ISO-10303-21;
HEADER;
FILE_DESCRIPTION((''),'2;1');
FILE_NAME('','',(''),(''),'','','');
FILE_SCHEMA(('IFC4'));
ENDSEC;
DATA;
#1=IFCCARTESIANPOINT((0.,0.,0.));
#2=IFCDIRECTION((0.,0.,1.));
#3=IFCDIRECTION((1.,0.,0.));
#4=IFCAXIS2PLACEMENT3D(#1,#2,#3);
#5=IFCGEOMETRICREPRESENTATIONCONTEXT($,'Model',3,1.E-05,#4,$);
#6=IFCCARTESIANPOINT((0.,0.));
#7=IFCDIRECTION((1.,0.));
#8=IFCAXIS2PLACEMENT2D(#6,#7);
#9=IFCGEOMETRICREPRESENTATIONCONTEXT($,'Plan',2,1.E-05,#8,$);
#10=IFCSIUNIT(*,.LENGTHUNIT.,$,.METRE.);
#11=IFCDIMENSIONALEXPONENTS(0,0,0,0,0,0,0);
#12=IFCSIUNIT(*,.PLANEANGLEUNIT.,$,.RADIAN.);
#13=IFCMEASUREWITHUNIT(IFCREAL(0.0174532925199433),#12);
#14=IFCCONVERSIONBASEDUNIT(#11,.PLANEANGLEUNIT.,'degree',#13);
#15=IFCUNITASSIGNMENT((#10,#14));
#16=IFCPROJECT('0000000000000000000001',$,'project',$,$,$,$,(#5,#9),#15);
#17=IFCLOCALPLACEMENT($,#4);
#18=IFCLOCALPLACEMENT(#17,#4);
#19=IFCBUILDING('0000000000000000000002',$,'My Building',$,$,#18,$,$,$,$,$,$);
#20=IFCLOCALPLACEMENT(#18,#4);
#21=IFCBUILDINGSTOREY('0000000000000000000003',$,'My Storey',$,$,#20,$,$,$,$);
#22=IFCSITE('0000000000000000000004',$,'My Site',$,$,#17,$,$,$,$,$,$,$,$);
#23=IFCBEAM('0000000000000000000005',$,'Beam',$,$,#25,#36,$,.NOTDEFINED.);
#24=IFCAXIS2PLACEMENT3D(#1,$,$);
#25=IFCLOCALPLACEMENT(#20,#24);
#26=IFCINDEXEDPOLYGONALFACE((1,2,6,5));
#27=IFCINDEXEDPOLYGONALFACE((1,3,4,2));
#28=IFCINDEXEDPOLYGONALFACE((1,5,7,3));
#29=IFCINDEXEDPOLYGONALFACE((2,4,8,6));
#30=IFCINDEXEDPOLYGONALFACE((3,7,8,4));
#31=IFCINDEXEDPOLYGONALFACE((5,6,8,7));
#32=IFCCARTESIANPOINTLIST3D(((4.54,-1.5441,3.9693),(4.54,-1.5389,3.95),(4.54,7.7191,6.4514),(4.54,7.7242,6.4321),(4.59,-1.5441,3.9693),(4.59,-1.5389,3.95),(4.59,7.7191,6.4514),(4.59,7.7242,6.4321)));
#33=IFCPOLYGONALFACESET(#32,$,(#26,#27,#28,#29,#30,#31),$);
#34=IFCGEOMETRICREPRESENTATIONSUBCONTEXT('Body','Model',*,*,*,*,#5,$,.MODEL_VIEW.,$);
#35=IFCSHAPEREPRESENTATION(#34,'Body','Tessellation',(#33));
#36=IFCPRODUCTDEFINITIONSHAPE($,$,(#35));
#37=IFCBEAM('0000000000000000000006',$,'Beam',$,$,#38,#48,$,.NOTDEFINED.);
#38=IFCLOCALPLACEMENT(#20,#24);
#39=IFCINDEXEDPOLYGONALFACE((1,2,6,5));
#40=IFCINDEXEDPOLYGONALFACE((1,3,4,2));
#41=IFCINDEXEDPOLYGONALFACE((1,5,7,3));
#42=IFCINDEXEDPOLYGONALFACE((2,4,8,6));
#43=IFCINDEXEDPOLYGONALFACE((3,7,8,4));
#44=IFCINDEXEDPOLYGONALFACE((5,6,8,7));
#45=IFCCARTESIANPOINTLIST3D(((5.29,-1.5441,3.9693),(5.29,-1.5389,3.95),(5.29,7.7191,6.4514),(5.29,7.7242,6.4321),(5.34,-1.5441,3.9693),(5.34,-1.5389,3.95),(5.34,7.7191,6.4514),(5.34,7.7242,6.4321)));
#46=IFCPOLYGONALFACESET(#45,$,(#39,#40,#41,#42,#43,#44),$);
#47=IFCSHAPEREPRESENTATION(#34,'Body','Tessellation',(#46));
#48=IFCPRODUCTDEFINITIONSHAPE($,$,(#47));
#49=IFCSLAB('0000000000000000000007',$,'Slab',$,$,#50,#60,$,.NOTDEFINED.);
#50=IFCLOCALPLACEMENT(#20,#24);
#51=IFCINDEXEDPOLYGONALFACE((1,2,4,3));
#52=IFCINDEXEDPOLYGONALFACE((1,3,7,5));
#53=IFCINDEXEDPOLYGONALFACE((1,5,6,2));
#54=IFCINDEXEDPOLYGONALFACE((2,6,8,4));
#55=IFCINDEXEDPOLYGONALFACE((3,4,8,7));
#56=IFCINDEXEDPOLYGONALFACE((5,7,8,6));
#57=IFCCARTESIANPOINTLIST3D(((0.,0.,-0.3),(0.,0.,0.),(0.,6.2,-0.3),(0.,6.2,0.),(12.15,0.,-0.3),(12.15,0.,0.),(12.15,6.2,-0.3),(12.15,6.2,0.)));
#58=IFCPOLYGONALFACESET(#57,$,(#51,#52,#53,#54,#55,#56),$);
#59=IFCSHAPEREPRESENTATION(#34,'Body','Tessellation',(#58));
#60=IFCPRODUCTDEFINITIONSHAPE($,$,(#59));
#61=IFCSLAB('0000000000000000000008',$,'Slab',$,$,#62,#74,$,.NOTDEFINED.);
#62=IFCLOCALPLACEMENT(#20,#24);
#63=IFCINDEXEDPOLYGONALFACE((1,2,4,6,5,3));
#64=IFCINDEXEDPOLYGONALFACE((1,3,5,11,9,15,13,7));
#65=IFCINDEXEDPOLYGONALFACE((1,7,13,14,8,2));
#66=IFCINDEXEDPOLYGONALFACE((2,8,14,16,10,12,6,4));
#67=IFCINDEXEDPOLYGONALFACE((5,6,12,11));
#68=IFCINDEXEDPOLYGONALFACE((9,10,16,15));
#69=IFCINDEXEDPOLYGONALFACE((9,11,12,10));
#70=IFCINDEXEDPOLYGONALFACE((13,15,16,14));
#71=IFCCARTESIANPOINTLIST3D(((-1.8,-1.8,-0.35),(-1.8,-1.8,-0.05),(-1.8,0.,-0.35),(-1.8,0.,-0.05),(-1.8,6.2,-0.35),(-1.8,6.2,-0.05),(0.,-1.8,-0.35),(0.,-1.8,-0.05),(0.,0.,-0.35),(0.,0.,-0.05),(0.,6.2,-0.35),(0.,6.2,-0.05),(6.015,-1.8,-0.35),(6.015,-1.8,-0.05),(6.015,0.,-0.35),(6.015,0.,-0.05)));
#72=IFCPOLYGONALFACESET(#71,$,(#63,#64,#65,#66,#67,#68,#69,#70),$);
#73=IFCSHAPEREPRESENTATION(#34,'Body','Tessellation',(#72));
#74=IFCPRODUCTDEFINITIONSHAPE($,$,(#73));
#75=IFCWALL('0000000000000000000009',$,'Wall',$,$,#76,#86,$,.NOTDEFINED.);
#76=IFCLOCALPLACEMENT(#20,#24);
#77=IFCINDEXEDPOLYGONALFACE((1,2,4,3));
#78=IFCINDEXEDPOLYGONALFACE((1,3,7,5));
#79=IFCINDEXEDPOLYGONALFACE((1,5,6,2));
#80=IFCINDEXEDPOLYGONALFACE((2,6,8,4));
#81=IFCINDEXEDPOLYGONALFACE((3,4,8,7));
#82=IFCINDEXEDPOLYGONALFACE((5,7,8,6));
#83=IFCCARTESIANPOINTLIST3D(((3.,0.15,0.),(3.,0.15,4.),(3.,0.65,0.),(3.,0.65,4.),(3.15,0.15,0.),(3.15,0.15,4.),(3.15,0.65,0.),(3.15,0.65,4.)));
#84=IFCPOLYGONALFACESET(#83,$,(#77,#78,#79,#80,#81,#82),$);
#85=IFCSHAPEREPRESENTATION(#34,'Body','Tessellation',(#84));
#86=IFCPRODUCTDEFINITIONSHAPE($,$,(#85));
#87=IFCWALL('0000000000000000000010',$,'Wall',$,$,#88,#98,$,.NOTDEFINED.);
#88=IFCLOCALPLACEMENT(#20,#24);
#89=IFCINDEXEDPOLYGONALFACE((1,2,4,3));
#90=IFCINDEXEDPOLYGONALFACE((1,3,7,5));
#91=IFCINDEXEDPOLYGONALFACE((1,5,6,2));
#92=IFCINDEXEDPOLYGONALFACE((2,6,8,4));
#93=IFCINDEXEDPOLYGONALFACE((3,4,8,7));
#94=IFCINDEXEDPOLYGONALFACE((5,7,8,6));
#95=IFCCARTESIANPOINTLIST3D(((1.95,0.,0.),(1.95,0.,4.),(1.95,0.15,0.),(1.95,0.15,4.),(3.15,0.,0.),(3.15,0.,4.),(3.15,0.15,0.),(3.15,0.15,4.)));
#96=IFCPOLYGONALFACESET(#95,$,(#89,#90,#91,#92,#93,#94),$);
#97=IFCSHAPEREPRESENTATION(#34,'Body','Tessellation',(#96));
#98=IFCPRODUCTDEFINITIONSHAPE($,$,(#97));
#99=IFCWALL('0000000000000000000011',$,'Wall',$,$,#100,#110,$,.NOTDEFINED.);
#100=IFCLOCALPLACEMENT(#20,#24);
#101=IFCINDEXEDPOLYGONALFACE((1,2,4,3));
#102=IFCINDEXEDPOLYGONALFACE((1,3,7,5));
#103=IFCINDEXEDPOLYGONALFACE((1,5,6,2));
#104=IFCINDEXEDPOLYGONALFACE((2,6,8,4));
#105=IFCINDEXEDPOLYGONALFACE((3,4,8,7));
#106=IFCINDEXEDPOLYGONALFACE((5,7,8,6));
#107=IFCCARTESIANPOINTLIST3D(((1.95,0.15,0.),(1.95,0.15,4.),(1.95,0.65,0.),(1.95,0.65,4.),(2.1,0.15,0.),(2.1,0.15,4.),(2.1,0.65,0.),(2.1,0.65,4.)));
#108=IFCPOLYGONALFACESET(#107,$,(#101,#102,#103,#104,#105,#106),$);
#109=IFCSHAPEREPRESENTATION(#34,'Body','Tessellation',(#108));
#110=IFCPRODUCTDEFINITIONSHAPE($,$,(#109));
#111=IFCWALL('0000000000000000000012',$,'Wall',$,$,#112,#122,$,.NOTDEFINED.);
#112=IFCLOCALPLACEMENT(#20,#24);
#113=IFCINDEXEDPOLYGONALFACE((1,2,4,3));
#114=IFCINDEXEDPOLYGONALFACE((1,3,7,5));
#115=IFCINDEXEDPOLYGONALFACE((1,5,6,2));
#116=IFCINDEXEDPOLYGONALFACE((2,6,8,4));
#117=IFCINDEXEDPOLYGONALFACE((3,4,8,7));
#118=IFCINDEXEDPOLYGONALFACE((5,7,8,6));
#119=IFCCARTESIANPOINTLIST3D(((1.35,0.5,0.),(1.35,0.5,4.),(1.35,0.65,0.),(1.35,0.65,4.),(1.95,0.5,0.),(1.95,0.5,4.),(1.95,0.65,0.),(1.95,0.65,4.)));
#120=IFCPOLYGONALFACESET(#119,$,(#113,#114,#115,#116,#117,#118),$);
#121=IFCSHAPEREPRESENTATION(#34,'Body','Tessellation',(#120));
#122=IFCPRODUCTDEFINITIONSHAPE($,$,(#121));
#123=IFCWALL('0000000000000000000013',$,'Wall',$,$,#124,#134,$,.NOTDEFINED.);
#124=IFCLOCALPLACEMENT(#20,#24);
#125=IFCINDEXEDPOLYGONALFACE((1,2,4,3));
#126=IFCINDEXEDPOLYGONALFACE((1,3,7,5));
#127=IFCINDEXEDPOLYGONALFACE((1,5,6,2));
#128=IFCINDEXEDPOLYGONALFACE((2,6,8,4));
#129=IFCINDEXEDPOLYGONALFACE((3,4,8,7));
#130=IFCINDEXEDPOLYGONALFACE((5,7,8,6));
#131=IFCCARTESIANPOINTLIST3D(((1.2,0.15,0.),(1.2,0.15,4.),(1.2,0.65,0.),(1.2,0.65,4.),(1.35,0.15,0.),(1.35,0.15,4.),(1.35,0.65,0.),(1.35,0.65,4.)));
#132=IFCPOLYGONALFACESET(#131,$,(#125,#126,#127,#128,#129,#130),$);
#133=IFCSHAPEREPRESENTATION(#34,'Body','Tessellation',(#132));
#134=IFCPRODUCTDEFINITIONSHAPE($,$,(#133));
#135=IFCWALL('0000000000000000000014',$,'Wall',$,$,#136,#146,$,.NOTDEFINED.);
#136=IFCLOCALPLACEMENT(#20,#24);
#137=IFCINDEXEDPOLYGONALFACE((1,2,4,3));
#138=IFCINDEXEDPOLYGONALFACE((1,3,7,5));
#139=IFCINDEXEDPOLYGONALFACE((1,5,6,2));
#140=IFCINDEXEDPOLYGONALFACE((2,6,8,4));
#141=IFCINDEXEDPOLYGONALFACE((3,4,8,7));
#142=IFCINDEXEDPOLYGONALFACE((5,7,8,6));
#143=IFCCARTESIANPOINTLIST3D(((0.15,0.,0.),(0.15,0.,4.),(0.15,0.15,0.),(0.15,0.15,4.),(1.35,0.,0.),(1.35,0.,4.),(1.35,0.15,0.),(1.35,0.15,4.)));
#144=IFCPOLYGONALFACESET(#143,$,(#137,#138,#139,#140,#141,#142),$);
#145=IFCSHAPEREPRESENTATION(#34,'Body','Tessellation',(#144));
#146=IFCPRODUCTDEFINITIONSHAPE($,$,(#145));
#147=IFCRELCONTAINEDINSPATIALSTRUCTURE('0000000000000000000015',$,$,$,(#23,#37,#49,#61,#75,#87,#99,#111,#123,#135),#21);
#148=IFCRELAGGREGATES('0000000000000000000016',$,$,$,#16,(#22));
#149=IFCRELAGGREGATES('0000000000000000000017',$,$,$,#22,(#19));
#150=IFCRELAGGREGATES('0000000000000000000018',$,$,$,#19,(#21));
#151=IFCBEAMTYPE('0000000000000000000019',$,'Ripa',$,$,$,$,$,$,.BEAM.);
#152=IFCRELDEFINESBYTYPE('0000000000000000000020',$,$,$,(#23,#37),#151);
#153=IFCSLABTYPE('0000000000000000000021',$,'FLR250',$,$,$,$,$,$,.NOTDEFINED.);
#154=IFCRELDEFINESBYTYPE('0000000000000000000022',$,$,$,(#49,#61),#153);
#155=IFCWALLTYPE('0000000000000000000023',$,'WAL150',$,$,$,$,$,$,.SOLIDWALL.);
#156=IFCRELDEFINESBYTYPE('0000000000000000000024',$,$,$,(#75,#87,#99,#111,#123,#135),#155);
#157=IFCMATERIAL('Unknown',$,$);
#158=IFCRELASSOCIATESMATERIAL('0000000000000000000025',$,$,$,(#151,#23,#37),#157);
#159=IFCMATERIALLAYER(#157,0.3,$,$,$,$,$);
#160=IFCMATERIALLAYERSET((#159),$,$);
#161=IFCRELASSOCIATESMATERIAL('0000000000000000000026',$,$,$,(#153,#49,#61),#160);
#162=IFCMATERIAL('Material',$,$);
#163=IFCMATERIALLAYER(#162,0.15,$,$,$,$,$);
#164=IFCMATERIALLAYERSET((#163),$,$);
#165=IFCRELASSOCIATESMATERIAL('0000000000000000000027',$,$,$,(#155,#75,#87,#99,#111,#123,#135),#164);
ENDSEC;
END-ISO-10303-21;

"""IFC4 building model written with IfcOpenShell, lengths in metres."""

from ifc_helpers import new_model, entity, si_unit, converted_unit, frame, origin_with_axes, origin_2d_with_axis, place, context, subcontext, project, spatial, line, indexed_curve, rectangle, outline, extrude, material, layer, layer_set, layer_usage, material_profile, profile_set, profile_usage, type_object, element, save


model = new_model("IFC4")

# Units and contexts
model_context = context("Model", 3, precision=1e-05, world=origin_with_axes())
plan_context = context("Plan", 2, precision=1e-05, world=origin_2d_with_axis())
body_context = subcontext(model_context, "Body", "Model", "MODEL_VIEW")
ifc_project = project(units=[si_unit("LENGTHUNIT", "METRE"), converted_unit("PLANEANGLEUNIT", "degree", entity("IfcReal", 0.0174532925199433), si_unit("PLANEANGLEUNIT", "RADIAN"), dimensions=[0, 0, 0, 0, 0, 0, 0])], contexts=[model_context, plan_context])

# Site, building, storey
site_placement = place(None, origin_with_axes())
site = spatial("IfcSite", under=ifc_project, at=site_placement, Name="My Site")
building_placement = place(site_placement, origin_with_axes())
building = spatial("IfcBuilding", under=site, at=building_placement, Name="My Building")
storey_placement = place(building_placement, origin_with_axes())
storey = spatial("IfcBuildingStorey", under=building, at=storey_placement, Name="My Storey")

# Beams
ifc_material_1 = material(Name="Unknown")
ifc_material_profile_1 = material_profile(ifc_material_1, rectangle(XDim=0.05, YDim=0.02))
ifc_profile_set_1 = profile_set([ifc_material_profile_1])
beam_type_1 = type_object("IfcBeamType", Name="Ripa", PredefinedType="BEAM", material=ifc_profile_set_1)
ifc_profile_usage_1 = profile_usage(ifc_profile_set_1, cardinal=2)
beam_1_placement = place(storey_placement, frame((4.565, -1.5389, 3.95), z_axis=(-0.000001, 0.965926, 0.25882), x_axis=(-1.0, -0.000001, 0.0)))
element("IfcBeam", 1, at=beam_1_placement, inside=storey, type_object=beam_type_1, material=ifc_profile_usage_1, Name="Beam", PredefinedType="NOTDEFINED", context=body_context, shape_type="SweptSolid", body=[
    extrude(rectangle(XDim=0.05, YDim=0.02), frame((0.0, 0.01, 0.0), z_axis=(0.0, 0.0, 1.0), x_axis=(1.0, 0.0, 0.0)), (0.0, 0.0, 1.0), 9.5899),
])
ifc_profile_usage_2 = profile_usage(ifc_profile_set_1, cardinal=2)
beam_2_placement = place(storey_placement, frame((5.315, -1.5389, 3.95), z_axis=(-0.000001, 0.965926, 0.25882), x_axis=(-1.0, -0.000001, 0.0)))
element("IfcBeam", 2, at=beam_2_placement, inside=storey, type_object=beam_type_1, material=ifc_profile_usage_2, Name="Beam", PredefinedType="NOTDEFINED", context=body_context, shape_type="SweptSolid", body=[
    extrude(rectangle(XDim=0.05, YDim=0.02), frame((0.0, 0.01, 0.0), z_axis=(0.0, 0.0, 1.0), x_axis=(1.0, 0.0, 0.0)), (0.0, 0.0, 1.0), 9.5899),
])

# Slabs
ifc_layer_1 = layer(ifc_material_1, 0.3)
ifc_layer_set_1 = layer_set([ifc_layer_1])
ifc_layer_usage_1 = layer_usage(ifc_layer_set_1, "AXIS3", "POSITIVE", 0.0)
slab_type = type_object("IfcSlabType", Name="FLR250", PredefinedType="NOTDEFINED", material=ifc_layer_set_1)
slab_1_placement = place(storey_placement, frame((0.0, 0.0, -0.3), z_axis=(0.0, 0.0, 1.0), x_axis=(1.0, 0.0, 0.0)))
element("IfcSlab", 3, at=slab_1_placement, inside=storey, type_object=slab_type, material=ifc_layer_usage_1, Name="Slab", PredefinedType="NOTDEFINED", context=body_context, shape_type="SweptSolid", body=[
    extrude(outline(indexed_curve([(0.0, 0.0), (12.15, 0.0), (12.15, 6.2), (0.0, 6.2)], segments=[line(3, 2), line(2, 1), line(1, 4), line(4, 3)], self_intersect=False)), None, (0.0, 0.0, 1.0), 0.3),
])
ifc_layer_usage_2 = layer_usage(ifc_layer_set_1, "AXIS3", "POSITIVE", 0.0)
slab_2_placement = place(storey_placement, frame((0.0, 0.0, -0.35), z_axis=(0.0, 0.0, 1.0), x_axis=(1.0, 0.0, 0.0)))
element("IfcSlab", 4, at=slab_2_placement, inside=storey, type_object=slab_type, material=ifc_layer_usage_2, Name="Slab", PredefinedType="NOTDEFINED", context=body_context, shape_type="SweptSolid", body=[
    extrude(outline(indexed_curve([(-1.8, 0.0), (0.0, 0.0), (0.0, 6.2), (-1.8, 6.2), (-1.8, -1.8), (0.0, -1.8), (6.015, 0.0), (6.015, -1.8)], segments=[line(1, 4), line(4, 3), line(3, 2), line(2, 7), line(7, 8), line(8, 6), line(6, 5), line(5, 1)], self_intersect=False)), None, (0.0, 0.0, 1.0), 0.3),
])

# Walls
ifc_material_2 = material(Name="Material")
ifc_layer_2 = layer(ifc_material_2, 0.15)
ifc_layer_set_2 = layer_set([ifc_layer_2])
ifc_layer_usage_3 = layer_usage(ifc_layer_set_2, "AXIS2", "POSITIVE", 0.0)
wall_type = type_object("IfcWallType", Name="WAL150", PredefinedType="SOLIDWALL", material=ifc_layer_set_2)
wall_1_placement = place(storey_placement, frame((3.0, 0.65, 0.0), z_axis=(0.0, 0.0, 1.0), x_axis=(-0.000001, -1.0, 0.0)))
element("IfcWall", 5, at=wall_1_placement, inside=storey, type_object=wall_type, material=ifc_layer_usage_3, Name="Wall", PredefinedType="NOTDEFINED", context=body_context, shape_type="SweptSolid", body=[
    extrude(outline(indexed_curve([(0.0, 0.0), (0.0, 0.15), (0.5, 0.15), (0.5, 0.0), (0.0, 0.0)], self_intersect=False)), origin_with_axes(), (0.0, 0.0, 1.0), 4.0),
])
ifc_layer_usage_4 = layer_usage(ifc_layer_set_2, "AXIS2", "POSITIVE", 0.0)
wall_2_placement = place(storey_placement, frame((3.15, 0.15, 0.0), z_axis=(0.0, 0.0, 1.0), x_axis=(-1.0, 0.0, 0.0)))
element("IfcWall", 6, at=wall_2_placement, inside=storey, type_object=wall_type, material=ifc_layer_usage_4, Name="Wall", PredefinedType="NOTDEFINED", context=body_context, shape_type="SweptSolid", body=[
    extrude(outline(indexed_curve([(0.0, 0.0), (0.0, 0.15), (1.2, 0.15), (1.2, 0.0), (0.0, 0.0)], self_intersect=False)), origin_with_axes(), (0.0, 0.0, 1.0), 4.0),
])
ifc_layer_usage_5 = layer_usage(ifc_layer_set_2, "AXIS2", "POSITIVE", 0.0)
wall_3_placement = place(storey_placement, frame((1.95, 0.65, 0.0), z_axis=(0.0, 0.0, 1.0), x_axis=(-0.000001, -1.0, 0.0)))
element("IfcWall", 7, at=wall_3_placement, inside=storey, type_object=wall_type, material=ifc_layer_usage_5, Name="Wall", PredefinedType="NOTDEFINED", context=body_context, shape_type="SweptSolid", body=[
    extrude(outline(indexed_curve([(0.0, 0.0), (0.0, 0.15), (0.5, 0.15), (0.5, 0.0), (0.0, 0.0)], self_intersect=False)), origin_with_axes(), (0.0, 0.0, 1.0), 4.0),
])
ifc_layer_usage_6 = layer_usage(ifc_layer_set_2, "AXIS2", "POSITIVE", 0.0)
wall_4_placement = place(storey_placement, frame((1.95, 0.65, 0.0), z_axis=(0.0, 0.0, 1.0), x_axis=(-1.0, 0.000001, 0.0)))
element("IfcWall", 8, at=wall_4_placement, inside=storey, type_object=wall_type, material=ifc_layer_usage_6, Name="Wall", PredefinedType="NOTDEFINED", context=body_context, shape_type="SweptSolid", body=[
    extrude(outline(indexed_curve([(0.0, 0.0), (0.0, 0.15), (0.6, 0.15), (0.6, 0.0), (0.0, 0.0)], self_intersect=False)), origin_with_axes(), (0.0, 0.0, 1.0), 4.0),
])
ifc_layer_usage_7 = layer_usage(ifc_layer_set_2, "AXIS2", "POSITIVE", 0.0)
wall_5_placement = place(storey_placement, frame((1.2, 0.65, 0.0), z_axis=(0.0, 0.0, 1.0), x_axis=(-0.000001, -1.0, 0.0)))
element("IfcWall", 9, at=wall_5_placement, inside=storey, type_object=wall_type, material=ifc_layer_usage_7, Name="Wall", PredefinedType="NOTDEFINED", context=body_context, shape_type="SweptSolid", body=[
    extrude(outline(indexed_curve([(0.0, 0.0), (0.0, 0.15), (0.5, 0.15), (0.5, 0.0), (0.0, 0.0)], self_intersect=False)), origin_with_axes(), (0.0, 0.0, 1.0), 4.0),
])
ifc_layer_usage_8 = layer_usage(ifc_layer_set_2, "AXIS2", "POSITIVE", 0.0)
wall_6_placement = place(storey_placement, frame((1.35, 0.15, 0.0), z_axis=(0.0, 0.0, 1.0), x_axis=(-1.0, 0.0, 0.0)))
element("IfcWall", 10, at=wall_6_placement, inside=storey, type_object=wall_type, material=ifc_layer_usage_8, Name="Wall", PredefinedType="NOTDEFINED", context=body_context, shape_type="SweptSolid", body=[
    extrude(outline(indexed_curve([(0.0, 0.0), (0.0, 0.15), (1.2, 0.15), (1.2, 0.0), (0.0, 0.0)], self_intersect=False)), origin_with_axes(), (0.0, 0.0, 1.0), 4.0),
])

save(model, "model.ifc")
